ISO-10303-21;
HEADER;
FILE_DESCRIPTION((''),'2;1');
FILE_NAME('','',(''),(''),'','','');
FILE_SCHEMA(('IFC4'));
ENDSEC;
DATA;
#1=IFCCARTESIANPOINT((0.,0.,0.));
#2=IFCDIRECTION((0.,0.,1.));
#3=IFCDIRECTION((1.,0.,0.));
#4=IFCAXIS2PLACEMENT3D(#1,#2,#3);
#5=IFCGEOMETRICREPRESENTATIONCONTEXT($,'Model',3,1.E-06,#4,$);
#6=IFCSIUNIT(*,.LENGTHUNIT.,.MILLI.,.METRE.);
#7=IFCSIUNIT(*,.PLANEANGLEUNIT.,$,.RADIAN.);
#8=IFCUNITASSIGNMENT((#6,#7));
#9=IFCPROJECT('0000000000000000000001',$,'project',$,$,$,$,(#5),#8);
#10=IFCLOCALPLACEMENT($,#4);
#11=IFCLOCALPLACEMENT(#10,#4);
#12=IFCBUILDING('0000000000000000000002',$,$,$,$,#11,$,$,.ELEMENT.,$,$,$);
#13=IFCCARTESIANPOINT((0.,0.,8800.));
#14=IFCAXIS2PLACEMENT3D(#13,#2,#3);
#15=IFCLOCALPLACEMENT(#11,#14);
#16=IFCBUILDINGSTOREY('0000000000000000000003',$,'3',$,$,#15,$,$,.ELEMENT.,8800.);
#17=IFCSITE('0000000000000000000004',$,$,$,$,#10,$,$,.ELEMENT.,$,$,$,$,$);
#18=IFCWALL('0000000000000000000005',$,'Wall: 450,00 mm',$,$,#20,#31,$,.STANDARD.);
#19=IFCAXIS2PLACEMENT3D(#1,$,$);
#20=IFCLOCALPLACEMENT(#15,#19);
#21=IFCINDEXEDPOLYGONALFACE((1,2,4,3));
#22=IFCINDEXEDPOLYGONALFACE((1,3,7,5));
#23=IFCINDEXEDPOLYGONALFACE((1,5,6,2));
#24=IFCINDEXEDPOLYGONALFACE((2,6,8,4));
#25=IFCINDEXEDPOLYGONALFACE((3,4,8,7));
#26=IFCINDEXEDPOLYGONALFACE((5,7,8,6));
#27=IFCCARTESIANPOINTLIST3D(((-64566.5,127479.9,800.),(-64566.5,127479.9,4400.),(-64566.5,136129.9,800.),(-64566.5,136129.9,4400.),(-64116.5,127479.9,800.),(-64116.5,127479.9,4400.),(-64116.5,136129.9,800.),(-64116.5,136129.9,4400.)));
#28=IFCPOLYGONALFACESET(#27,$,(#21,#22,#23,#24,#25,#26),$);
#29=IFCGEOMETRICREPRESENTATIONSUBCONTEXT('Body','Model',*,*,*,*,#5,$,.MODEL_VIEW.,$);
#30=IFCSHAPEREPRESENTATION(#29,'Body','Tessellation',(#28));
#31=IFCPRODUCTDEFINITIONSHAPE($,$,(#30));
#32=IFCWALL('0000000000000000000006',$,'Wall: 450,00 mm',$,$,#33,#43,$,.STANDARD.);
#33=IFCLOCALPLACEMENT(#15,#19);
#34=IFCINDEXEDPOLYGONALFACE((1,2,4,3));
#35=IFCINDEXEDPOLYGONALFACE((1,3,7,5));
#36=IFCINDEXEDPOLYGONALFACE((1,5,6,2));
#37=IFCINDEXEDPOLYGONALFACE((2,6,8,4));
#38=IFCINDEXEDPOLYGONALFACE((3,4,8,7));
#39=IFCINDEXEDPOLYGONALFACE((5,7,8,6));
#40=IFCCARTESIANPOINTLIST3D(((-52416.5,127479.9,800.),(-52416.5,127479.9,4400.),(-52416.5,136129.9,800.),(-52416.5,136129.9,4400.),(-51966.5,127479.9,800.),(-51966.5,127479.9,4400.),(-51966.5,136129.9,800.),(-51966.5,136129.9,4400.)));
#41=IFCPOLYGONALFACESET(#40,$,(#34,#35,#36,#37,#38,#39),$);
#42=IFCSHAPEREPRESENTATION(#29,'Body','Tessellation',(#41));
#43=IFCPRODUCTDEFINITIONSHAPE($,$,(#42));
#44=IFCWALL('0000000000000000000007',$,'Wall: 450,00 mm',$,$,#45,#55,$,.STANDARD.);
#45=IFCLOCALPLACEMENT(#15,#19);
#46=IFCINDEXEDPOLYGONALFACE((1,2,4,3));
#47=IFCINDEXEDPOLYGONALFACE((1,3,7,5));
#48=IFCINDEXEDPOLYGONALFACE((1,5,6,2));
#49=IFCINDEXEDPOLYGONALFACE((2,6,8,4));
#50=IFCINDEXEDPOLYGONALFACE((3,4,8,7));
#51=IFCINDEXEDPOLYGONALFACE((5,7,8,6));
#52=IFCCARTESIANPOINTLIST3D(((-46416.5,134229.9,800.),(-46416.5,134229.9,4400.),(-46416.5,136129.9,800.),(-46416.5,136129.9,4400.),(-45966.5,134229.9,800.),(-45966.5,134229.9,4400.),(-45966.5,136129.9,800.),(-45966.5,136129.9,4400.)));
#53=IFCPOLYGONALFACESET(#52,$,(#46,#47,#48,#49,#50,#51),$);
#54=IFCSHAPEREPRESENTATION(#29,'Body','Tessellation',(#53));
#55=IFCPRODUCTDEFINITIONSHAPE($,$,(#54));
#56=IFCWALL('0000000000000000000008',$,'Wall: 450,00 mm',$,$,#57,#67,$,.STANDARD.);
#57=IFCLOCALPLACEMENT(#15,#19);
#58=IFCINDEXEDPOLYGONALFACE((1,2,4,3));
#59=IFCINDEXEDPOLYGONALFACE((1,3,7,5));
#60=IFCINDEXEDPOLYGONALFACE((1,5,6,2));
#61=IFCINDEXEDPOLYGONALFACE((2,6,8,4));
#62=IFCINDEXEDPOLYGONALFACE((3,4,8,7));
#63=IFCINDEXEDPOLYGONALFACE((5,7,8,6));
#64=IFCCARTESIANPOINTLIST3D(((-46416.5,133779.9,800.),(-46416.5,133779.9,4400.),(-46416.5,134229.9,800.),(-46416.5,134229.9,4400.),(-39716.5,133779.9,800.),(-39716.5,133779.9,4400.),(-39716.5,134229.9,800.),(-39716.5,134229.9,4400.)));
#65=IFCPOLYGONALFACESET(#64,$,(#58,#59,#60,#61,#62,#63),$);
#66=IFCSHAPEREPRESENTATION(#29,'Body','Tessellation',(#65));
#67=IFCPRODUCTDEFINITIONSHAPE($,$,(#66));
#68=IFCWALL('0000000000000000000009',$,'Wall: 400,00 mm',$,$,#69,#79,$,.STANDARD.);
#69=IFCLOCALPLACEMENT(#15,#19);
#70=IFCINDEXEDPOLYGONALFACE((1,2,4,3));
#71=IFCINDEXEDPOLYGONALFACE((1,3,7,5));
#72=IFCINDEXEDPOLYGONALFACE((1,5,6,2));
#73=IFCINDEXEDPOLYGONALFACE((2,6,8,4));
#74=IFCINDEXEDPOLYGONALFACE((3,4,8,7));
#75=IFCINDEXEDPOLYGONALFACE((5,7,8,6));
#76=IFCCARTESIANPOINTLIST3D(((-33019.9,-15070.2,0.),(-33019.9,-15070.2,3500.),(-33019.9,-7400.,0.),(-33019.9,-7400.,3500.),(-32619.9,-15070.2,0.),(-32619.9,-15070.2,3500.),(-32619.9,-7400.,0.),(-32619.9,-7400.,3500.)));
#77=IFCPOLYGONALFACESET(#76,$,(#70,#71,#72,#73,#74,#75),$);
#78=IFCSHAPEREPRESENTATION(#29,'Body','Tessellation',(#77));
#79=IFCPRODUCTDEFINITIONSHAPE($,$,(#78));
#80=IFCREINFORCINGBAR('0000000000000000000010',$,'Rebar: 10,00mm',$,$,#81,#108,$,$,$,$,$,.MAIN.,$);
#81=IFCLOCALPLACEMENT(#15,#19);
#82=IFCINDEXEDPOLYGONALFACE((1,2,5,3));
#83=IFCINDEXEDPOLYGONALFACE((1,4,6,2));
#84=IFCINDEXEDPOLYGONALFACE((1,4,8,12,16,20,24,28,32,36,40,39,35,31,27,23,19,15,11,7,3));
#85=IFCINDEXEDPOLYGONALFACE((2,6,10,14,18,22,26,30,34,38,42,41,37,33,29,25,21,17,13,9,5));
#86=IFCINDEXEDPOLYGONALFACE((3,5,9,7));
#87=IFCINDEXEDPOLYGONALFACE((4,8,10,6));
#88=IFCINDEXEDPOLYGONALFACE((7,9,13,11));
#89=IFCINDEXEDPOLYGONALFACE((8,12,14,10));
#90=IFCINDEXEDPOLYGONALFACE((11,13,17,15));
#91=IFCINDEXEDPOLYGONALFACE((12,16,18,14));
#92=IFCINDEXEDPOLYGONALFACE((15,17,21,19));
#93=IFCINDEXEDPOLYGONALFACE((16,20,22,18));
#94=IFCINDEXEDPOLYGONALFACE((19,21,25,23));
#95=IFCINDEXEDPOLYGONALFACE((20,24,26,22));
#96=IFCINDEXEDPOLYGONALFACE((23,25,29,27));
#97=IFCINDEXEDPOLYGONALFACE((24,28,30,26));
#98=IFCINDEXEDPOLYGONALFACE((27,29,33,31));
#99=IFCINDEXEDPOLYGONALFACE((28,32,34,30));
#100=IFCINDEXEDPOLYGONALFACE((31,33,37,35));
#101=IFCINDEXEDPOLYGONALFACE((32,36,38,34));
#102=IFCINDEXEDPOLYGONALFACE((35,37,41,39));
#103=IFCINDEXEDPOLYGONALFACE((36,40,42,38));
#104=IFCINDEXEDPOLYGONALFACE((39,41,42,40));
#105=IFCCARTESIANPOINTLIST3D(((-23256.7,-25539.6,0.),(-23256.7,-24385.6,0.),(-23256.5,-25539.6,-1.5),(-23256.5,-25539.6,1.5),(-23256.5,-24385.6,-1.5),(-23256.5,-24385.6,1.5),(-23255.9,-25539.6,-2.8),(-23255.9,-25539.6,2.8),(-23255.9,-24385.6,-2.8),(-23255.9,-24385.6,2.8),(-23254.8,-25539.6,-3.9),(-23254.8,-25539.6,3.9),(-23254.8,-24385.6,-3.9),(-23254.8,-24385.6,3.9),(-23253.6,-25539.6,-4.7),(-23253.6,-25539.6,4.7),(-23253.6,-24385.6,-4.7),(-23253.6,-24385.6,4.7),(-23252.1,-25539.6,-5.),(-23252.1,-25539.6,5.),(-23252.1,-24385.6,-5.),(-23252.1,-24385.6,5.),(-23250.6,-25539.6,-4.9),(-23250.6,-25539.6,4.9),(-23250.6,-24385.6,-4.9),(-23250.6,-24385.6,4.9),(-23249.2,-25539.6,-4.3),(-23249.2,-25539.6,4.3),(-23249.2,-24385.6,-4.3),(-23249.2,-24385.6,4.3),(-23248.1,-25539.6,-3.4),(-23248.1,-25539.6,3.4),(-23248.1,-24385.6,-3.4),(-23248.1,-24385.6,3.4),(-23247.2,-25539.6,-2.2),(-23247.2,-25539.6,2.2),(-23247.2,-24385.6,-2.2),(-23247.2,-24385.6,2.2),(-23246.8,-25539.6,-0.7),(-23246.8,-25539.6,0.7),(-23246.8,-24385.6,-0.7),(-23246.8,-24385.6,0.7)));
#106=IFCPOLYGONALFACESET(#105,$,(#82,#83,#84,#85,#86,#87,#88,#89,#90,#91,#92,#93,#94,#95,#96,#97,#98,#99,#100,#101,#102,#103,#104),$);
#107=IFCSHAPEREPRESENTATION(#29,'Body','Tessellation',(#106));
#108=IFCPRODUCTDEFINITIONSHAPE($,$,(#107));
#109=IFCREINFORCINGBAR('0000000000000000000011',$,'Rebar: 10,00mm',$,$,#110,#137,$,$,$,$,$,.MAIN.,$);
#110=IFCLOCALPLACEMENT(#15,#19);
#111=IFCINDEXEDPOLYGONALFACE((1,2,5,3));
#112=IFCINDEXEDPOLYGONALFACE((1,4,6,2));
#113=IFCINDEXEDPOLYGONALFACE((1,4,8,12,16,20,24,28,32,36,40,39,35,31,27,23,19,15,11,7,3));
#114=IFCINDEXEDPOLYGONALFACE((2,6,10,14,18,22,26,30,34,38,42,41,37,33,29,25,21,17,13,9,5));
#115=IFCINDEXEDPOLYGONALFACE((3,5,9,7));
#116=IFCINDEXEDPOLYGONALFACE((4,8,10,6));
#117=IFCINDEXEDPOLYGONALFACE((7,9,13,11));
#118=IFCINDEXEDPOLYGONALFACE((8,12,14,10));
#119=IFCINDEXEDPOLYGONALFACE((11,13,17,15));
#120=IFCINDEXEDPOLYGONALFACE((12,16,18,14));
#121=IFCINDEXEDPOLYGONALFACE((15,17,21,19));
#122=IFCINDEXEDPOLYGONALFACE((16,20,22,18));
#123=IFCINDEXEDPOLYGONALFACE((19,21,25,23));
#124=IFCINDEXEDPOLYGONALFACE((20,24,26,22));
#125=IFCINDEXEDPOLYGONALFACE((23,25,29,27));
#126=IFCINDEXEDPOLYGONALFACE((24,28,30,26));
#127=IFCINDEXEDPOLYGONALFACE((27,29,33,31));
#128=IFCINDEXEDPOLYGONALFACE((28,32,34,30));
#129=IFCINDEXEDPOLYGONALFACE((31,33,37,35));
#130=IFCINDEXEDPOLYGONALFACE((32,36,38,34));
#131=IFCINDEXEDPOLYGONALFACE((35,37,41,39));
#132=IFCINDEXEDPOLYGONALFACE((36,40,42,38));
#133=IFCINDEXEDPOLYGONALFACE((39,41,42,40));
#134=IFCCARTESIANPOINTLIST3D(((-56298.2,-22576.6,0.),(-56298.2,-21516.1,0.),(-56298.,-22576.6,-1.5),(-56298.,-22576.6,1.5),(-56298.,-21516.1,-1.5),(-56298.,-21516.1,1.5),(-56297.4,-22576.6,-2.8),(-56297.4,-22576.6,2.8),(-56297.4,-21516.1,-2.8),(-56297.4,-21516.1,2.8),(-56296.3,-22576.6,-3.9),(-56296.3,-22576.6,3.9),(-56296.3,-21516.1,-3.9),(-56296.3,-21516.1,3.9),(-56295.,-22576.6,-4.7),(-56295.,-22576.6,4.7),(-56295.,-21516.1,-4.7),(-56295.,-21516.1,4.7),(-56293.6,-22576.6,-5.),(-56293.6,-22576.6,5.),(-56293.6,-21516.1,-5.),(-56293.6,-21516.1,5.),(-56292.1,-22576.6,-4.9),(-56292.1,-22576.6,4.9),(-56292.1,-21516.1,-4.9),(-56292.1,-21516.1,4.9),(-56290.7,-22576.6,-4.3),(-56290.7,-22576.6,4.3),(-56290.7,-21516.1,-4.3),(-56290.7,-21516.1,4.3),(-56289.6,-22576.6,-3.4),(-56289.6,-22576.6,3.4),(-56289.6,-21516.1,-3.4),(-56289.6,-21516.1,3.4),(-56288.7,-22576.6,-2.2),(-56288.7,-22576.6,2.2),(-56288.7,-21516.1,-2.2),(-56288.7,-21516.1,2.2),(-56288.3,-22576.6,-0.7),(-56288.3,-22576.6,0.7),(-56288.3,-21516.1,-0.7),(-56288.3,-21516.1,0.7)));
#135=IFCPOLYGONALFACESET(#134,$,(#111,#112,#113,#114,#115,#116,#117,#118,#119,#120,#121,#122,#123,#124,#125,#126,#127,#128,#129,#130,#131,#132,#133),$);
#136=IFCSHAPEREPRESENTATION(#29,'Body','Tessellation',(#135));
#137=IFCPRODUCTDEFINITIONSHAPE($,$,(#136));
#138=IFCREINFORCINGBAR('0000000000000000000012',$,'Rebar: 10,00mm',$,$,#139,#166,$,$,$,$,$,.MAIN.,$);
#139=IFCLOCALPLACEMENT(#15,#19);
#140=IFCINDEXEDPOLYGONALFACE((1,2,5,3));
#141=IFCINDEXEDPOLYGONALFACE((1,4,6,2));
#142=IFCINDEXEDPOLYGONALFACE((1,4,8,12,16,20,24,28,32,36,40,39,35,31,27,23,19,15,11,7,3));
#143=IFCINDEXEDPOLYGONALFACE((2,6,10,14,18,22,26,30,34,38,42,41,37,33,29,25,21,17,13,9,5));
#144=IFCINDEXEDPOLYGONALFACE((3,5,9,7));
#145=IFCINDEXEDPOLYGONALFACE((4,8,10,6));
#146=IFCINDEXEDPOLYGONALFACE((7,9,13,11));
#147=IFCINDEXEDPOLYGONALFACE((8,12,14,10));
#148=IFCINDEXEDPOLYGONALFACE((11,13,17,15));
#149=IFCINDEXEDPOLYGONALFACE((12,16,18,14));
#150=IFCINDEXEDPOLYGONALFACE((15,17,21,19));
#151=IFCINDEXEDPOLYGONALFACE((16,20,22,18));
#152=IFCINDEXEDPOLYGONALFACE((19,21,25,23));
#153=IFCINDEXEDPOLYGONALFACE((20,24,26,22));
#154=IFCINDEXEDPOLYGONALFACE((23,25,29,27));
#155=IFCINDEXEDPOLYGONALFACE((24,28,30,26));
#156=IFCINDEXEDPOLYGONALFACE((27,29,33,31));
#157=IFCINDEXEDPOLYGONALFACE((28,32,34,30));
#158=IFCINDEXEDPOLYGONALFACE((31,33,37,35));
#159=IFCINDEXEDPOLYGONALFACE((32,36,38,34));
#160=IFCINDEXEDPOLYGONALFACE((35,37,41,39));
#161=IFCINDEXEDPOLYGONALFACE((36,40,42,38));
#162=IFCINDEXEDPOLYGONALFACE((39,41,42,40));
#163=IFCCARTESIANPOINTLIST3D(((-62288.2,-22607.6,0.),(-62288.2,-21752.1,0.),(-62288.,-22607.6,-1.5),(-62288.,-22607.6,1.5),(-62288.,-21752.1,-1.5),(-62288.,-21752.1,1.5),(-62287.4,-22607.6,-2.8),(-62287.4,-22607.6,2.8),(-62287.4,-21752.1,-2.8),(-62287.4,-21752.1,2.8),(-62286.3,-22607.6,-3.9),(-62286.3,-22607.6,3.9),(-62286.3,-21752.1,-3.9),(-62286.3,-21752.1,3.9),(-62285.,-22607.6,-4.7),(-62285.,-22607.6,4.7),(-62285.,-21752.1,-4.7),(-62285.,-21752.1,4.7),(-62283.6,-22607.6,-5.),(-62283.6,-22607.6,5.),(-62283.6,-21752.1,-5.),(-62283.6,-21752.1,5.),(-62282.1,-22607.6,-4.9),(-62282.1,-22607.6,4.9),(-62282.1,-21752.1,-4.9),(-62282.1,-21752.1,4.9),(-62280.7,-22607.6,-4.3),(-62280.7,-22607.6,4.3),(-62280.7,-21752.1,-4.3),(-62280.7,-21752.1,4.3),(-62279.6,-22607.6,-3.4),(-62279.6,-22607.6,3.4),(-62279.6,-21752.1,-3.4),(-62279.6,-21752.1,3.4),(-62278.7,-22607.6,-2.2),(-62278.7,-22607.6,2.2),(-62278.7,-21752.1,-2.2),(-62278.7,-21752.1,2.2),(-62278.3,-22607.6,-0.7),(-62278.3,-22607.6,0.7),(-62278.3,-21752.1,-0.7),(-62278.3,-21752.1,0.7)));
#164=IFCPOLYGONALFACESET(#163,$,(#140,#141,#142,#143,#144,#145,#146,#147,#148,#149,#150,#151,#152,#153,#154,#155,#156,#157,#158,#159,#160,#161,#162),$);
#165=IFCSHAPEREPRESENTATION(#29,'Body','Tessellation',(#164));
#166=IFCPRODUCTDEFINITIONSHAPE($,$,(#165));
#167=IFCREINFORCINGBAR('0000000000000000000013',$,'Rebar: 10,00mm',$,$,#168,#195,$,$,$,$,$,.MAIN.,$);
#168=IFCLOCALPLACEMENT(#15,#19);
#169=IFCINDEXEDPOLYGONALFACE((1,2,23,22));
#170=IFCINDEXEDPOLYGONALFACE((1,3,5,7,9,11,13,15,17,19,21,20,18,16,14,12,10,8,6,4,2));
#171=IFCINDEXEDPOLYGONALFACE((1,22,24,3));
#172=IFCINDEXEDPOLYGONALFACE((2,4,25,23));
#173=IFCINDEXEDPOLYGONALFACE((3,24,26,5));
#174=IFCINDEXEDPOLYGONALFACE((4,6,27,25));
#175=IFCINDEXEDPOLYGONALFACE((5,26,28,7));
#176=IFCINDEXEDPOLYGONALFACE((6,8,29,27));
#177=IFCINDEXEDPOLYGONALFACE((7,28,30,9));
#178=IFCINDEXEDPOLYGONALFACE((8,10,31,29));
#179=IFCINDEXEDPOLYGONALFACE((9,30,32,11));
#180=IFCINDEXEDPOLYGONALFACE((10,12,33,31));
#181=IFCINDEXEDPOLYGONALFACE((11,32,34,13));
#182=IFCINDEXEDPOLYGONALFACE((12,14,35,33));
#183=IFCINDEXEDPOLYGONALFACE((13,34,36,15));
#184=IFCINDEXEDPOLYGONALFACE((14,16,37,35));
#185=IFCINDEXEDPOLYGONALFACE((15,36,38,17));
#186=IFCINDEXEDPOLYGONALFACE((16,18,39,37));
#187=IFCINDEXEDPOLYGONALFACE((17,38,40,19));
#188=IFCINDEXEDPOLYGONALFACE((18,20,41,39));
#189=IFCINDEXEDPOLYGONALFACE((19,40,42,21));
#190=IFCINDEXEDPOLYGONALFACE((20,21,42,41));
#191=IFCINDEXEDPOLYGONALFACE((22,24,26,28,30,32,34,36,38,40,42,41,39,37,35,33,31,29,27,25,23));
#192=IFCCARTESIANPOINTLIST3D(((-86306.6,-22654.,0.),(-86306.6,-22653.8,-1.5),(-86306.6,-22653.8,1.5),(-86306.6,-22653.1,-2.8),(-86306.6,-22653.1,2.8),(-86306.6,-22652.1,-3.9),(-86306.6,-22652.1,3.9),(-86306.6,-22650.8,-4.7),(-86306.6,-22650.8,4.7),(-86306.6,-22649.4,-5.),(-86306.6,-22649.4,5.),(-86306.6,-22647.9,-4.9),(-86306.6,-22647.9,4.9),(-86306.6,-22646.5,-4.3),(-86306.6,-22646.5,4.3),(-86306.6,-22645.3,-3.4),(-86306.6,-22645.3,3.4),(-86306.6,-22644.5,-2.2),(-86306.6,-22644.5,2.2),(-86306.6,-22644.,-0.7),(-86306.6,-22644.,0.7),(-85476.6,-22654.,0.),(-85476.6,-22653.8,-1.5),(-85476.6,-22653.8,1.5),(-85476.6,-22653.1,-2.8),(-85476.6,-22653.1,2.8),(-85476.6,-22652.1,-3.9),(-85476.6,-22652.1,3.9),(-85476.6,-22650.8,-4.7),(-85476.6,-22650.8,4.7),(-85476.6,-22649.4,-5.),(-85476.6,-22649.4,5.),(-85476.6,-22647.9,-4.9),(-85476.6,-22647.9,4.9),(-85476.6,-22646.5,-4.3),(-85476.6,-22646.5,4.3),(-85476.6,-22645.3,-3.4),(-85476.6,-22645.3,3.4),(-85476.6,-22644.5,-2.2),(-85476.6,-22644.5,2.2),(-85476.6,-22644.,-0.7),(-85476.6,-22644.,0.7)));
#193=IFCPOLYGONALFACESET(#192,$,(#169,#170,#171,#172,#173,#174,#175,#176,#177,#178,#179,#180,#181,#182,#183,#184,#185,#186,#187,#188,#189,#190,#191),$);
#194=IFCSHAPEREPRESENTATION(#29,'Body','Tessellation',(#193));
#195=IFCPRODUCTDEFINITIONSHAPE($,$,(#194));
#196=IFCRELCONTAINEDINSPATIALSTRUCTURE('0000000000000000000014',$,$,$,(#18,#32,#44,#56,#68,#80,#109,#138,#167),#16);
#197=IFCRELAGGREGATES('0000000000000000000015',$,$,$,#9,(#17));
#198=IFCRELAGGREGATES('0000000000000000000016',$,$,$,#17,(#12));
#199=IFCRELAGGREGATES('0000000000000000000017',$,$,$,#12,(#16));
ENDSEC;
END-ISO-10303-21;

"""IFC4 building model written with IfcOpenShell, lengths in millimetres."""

from ifc_helpers import new_model, entity, si_unit, frame, origin_with_axes, place, context, subcontext, project, spatial, line, indexed_curve, outline, extrude, source, transform, mapped, element, save


model = new_model("IFC4")

# Units and contexts
model_context = context("Model", 3, precision=1e-06, world=origin_with_axes())
body_context = subcontext(model_context, "Body", "Model", "MODEL_VIEW")
ifc_project = project(units=[si_unit("LENGTHUNIT", "METRE", prefix="MILLI"), si_unit("PLANEANGLEUNIT", "RADIAN")], contexts=[model_context])

# Site, building, storey
site_placement = place(None, origin_with_axes())
site = spatial("IfcSite", under=ifc_project, at=site_placement, CompositionType="ELEMENT")
building_placement = place(site_placement, origin_with_axes())
building = spatial("IfcBuilding", under=site, at=building_placement, CompositionType="ELEMENT")
storey_placement = place(building_placement, frame((0.0, 0.0, 8800.0), z_axis=(0.0, 0.0, 1.0), x_axis=(1.0, 0.0, 0.0)))
storey = spatial("IfcBuildingStorey", under=building, at=storey_placement, Name="3", CompositionType="ELEMENT", Elevation=8800.0)

# Walls
wall_1_placement = place(storey_placement, frame((-64566.5, 136129.9, 800.0), z_axis=(0.0, 0.0, 1.0), x_axis=(0.0, -1.0, 0.0)))
element("IfcWall", 1, at=wall_1_placement, inside=storey, Name="Wall: 450,00 mm", PredefinedType="STANDARD", context=body_context, shape_type="SweptSolid", body=[
    extrude(outline(indexed_curve([(0.0, 0.0), (8650.0, 0.0), (8650.0, 450.0), (0.0, 450.0)], segments=[line(1, 2), line(2, 3), line(3, 4), line(4, 1)])), origin_with_axes(), (0.0, 0.0, 1.0), 3600.0),
])
wall_2_placement = place(storey_placement, frame((-52416.5, 136129.9, 800.0), z_axis=(0.0, 0.0, 1.0), x_axis=(0.0, -1.0, 0.0)))
element("IfcWall", 2, at=wall_2_placement, inside=storey, Name="Wall: 450,00 mm", PredefinedType="STANDARD", context=body_context, shape_type="SweptSolid", body=[
    extrude(outline(indexed_curve([(0.0, 0.0), (8650.0, 0.0), (8650.0, 450.0), (0.0, 450.0)], segments=[line(1, 2), line(2, 3), line(3, 4), line(4, 1)])), origin_with_axes(), (0.0, 0.0, 1.0), 3600.0),
])
wall_3_placement = place(storey_placement, frame((-45966.5, 136129.9, 800.0), z_axis=(0.0, 0.0, 1.0), x_axis=(0.0, -1.0, 0.0)))
element("IfcWall", 3, at=wall_3_placement, inside=storey, Name="Wall: 450,00 mm", PredefinedType="STANDARD", context=body_context, shape_type="SweptSolid", body=[
    extrude(outline(indexed_curve([(0.0, -450.0), (1900.0, -450.0), (1900.0, 0.0), (0.0, 0.0)], segments=[line(1, 2), line(2, 3), line(3, 4), line(4, 1)])), origin_with_axes(), (0.0, 0.0, 1.0), 3600.0),
])
wall_4_placement = place(storey_placement, frame((-46416.5, 133779.9, 800.0), z_axis=(0.0, 0.0, 1.0), x_axis=(1.0, 0.0, 0.0)))
element("IfcWall", 4, at=wall_4_placement, inside=storey, Name="Wall: 450,00 mm", PredefinedType="STANDARD", context=body_context, shape_type="SweptSolid", body=[
    extrude(outline(indexed_curve([(0.0, 0.0), (6700.0, 0.0), (6700.0, 450.0), (0.0, 450.0)], segments=[line(1, 2), line(2, 3), line(3, 4), line(4, 1)])), origin_with_axes(), (0.0, 0.0, 1.0), 3600.0),
])
wall_5_placement = place(storey_placement, frame((-33019.9, -7400.0, 0.0), z_axis=(0.0, 0.0, 1.0), x_axis=(0.0, -1.0, 0.0)))
element("IfcWall", 5, at=wall_5_placement, inside=storey, Name="Wall: 400,00 mm", PredefinedType="STANDARD", context=body_context, shape_type="SweptSolid", body=[
    extrude(outline(indexed_curve([(0.0, 0.0), (7670.2, 0.0), (7670.2, 400.0), (0.0, 400.0)], segments=[line(1, 2), line(2, 3), line(3, 4), line(4, 1)])), origin_with_axes(), (0.0, 0.0, 1.0), 3500.0),
])

# Reinforcing bars
shared_shape_1 = source(origin_with_axes(), body_context, "Body", "AdvancedSweptSolid", [
    entity("IfcSweptDiskSolid", entity("IfcIndexedPolyCurve", entity("IfcCartesianPointList3D", [[0.0, 0.0, 0.0], [1154.0, 0.0, 0.0]]), [entity("IfcLineIndex", [1, 2])]), 5.0),
])
reinforcing_bar_1_placement = place(storey_placement, origin_with_axes())
element("IfcReinforcingBar", 6, at=reinforcing_bar_1_placement, inside=storey, Name="Rebar: 10,00mm", PredefinedType="MAIN", context=body_context, shape_type="MappedRepresentation", body=[
    mapped(shared_shape_1, transform((-23251.7, -25539.6, 0.0), x_axis=(0.0, 1.0, 0.0), y_axis=(-1.0, 0.0, 0.0), z_axis=(0.0, 0.0, 1.0), scale=1.0)),
])
shared_shape_2 = source(origin_with_axes(), body_context, "Body", "AdvancedSweptSolid", [
    entity("IfcSweptDiskSolid", entity("IfcIndexedPolyCurve", entity("IfcCartesianPointList3D", [[0.0, 0.0, 0.0], [1060.6, 0.0, 0.0]]), [entity("IfcLineIndex", [1, 2])]), 5.0),
])
reinforcing_bar_2_placement = place(storey_placement, origin_with_axes())
element("IfcReinforcingBar", 7, at=reinforcing_bar_2_placement, inside=storey, Name="Rebar: 10,00mm", PredefinedType="MAIN", context=body_context, shape_type="MappedRepresentation", body=[
    mapped(shared_shape_2, transform((-56293.2, -22576.6, 0.0), x_axis=(0.0, 1.0, 0.0), y_axis=(-1.0, 0.0, 0.0), z_axis=(0.0, 0.0, 1.0), scale=1.0)),
])
shared_shape_3 = source(origin_with_axes(), body_context, "Body", "AdvancedSweptSolid", [
    entity("IfcSweptDiskSolid", entity("IfcIndexedPolyCurve", entity("IfcCartesianPointList3D", [[0.0, 0.0, 0.0], [855.4, 0.0, 0.0]]), [entity("IfcLineIndex", [1, 2])]), 5.0),
])
reinforcing_bar_3_placement = place(storey_placement, origin_with_axes())
element("IfcReinforcingBar", 8, at=reinforcing_bar_3_placement, inside=storey, Name="Rebar: 10,00mm", PredefinedType="MAIN", context=body_context, shape_type="MappedRepresentation", body=[
    mapped(shared_shape_3, transform((-62283.2, -22607.6, 0.0), x_axis=(0.0, 1.0, 0.0), y_axis=(-1.0, 0.0, 0.0), z_axis=(0.0, 0.0, 1.0), scale=1.0)),
])
shared_shape_4 = source(origin_with_axes(), body_context, "Body", "AdvancedSweptSolid", [
    entity("IfcSweptDiskSolid", entity("IfcIndexedPolyCurve", entity("IfcCartesianPointList3D", [[0.0, 0.0, 0.0], [830.0, 0.0, 0.0]]), [entity("IfcLineIndex", [1, 2])]), 5.0),
])
reinforcing_bar_4_placement = place(storey_placement, origin_with_axes())
element("IfcReinforcingBar", 9, at=reinforcing_bar_4_placement, inside=storey, Name="Rebar: 10,00mm", PredefinedType="MAIN", context=body_context, shape_type="MappedRepresentation", body=[
    mapped(shared_shape_4, transform((-85476.6, -22649.0, 0.0), x_axis=(-1.0, 0.0, 0.0), y_axis=(0.0, -1.0, 0.0), z_axis=(0.0, 0.0, 1.0), scale=1.0)),
])

save(model, "model.ifc")
